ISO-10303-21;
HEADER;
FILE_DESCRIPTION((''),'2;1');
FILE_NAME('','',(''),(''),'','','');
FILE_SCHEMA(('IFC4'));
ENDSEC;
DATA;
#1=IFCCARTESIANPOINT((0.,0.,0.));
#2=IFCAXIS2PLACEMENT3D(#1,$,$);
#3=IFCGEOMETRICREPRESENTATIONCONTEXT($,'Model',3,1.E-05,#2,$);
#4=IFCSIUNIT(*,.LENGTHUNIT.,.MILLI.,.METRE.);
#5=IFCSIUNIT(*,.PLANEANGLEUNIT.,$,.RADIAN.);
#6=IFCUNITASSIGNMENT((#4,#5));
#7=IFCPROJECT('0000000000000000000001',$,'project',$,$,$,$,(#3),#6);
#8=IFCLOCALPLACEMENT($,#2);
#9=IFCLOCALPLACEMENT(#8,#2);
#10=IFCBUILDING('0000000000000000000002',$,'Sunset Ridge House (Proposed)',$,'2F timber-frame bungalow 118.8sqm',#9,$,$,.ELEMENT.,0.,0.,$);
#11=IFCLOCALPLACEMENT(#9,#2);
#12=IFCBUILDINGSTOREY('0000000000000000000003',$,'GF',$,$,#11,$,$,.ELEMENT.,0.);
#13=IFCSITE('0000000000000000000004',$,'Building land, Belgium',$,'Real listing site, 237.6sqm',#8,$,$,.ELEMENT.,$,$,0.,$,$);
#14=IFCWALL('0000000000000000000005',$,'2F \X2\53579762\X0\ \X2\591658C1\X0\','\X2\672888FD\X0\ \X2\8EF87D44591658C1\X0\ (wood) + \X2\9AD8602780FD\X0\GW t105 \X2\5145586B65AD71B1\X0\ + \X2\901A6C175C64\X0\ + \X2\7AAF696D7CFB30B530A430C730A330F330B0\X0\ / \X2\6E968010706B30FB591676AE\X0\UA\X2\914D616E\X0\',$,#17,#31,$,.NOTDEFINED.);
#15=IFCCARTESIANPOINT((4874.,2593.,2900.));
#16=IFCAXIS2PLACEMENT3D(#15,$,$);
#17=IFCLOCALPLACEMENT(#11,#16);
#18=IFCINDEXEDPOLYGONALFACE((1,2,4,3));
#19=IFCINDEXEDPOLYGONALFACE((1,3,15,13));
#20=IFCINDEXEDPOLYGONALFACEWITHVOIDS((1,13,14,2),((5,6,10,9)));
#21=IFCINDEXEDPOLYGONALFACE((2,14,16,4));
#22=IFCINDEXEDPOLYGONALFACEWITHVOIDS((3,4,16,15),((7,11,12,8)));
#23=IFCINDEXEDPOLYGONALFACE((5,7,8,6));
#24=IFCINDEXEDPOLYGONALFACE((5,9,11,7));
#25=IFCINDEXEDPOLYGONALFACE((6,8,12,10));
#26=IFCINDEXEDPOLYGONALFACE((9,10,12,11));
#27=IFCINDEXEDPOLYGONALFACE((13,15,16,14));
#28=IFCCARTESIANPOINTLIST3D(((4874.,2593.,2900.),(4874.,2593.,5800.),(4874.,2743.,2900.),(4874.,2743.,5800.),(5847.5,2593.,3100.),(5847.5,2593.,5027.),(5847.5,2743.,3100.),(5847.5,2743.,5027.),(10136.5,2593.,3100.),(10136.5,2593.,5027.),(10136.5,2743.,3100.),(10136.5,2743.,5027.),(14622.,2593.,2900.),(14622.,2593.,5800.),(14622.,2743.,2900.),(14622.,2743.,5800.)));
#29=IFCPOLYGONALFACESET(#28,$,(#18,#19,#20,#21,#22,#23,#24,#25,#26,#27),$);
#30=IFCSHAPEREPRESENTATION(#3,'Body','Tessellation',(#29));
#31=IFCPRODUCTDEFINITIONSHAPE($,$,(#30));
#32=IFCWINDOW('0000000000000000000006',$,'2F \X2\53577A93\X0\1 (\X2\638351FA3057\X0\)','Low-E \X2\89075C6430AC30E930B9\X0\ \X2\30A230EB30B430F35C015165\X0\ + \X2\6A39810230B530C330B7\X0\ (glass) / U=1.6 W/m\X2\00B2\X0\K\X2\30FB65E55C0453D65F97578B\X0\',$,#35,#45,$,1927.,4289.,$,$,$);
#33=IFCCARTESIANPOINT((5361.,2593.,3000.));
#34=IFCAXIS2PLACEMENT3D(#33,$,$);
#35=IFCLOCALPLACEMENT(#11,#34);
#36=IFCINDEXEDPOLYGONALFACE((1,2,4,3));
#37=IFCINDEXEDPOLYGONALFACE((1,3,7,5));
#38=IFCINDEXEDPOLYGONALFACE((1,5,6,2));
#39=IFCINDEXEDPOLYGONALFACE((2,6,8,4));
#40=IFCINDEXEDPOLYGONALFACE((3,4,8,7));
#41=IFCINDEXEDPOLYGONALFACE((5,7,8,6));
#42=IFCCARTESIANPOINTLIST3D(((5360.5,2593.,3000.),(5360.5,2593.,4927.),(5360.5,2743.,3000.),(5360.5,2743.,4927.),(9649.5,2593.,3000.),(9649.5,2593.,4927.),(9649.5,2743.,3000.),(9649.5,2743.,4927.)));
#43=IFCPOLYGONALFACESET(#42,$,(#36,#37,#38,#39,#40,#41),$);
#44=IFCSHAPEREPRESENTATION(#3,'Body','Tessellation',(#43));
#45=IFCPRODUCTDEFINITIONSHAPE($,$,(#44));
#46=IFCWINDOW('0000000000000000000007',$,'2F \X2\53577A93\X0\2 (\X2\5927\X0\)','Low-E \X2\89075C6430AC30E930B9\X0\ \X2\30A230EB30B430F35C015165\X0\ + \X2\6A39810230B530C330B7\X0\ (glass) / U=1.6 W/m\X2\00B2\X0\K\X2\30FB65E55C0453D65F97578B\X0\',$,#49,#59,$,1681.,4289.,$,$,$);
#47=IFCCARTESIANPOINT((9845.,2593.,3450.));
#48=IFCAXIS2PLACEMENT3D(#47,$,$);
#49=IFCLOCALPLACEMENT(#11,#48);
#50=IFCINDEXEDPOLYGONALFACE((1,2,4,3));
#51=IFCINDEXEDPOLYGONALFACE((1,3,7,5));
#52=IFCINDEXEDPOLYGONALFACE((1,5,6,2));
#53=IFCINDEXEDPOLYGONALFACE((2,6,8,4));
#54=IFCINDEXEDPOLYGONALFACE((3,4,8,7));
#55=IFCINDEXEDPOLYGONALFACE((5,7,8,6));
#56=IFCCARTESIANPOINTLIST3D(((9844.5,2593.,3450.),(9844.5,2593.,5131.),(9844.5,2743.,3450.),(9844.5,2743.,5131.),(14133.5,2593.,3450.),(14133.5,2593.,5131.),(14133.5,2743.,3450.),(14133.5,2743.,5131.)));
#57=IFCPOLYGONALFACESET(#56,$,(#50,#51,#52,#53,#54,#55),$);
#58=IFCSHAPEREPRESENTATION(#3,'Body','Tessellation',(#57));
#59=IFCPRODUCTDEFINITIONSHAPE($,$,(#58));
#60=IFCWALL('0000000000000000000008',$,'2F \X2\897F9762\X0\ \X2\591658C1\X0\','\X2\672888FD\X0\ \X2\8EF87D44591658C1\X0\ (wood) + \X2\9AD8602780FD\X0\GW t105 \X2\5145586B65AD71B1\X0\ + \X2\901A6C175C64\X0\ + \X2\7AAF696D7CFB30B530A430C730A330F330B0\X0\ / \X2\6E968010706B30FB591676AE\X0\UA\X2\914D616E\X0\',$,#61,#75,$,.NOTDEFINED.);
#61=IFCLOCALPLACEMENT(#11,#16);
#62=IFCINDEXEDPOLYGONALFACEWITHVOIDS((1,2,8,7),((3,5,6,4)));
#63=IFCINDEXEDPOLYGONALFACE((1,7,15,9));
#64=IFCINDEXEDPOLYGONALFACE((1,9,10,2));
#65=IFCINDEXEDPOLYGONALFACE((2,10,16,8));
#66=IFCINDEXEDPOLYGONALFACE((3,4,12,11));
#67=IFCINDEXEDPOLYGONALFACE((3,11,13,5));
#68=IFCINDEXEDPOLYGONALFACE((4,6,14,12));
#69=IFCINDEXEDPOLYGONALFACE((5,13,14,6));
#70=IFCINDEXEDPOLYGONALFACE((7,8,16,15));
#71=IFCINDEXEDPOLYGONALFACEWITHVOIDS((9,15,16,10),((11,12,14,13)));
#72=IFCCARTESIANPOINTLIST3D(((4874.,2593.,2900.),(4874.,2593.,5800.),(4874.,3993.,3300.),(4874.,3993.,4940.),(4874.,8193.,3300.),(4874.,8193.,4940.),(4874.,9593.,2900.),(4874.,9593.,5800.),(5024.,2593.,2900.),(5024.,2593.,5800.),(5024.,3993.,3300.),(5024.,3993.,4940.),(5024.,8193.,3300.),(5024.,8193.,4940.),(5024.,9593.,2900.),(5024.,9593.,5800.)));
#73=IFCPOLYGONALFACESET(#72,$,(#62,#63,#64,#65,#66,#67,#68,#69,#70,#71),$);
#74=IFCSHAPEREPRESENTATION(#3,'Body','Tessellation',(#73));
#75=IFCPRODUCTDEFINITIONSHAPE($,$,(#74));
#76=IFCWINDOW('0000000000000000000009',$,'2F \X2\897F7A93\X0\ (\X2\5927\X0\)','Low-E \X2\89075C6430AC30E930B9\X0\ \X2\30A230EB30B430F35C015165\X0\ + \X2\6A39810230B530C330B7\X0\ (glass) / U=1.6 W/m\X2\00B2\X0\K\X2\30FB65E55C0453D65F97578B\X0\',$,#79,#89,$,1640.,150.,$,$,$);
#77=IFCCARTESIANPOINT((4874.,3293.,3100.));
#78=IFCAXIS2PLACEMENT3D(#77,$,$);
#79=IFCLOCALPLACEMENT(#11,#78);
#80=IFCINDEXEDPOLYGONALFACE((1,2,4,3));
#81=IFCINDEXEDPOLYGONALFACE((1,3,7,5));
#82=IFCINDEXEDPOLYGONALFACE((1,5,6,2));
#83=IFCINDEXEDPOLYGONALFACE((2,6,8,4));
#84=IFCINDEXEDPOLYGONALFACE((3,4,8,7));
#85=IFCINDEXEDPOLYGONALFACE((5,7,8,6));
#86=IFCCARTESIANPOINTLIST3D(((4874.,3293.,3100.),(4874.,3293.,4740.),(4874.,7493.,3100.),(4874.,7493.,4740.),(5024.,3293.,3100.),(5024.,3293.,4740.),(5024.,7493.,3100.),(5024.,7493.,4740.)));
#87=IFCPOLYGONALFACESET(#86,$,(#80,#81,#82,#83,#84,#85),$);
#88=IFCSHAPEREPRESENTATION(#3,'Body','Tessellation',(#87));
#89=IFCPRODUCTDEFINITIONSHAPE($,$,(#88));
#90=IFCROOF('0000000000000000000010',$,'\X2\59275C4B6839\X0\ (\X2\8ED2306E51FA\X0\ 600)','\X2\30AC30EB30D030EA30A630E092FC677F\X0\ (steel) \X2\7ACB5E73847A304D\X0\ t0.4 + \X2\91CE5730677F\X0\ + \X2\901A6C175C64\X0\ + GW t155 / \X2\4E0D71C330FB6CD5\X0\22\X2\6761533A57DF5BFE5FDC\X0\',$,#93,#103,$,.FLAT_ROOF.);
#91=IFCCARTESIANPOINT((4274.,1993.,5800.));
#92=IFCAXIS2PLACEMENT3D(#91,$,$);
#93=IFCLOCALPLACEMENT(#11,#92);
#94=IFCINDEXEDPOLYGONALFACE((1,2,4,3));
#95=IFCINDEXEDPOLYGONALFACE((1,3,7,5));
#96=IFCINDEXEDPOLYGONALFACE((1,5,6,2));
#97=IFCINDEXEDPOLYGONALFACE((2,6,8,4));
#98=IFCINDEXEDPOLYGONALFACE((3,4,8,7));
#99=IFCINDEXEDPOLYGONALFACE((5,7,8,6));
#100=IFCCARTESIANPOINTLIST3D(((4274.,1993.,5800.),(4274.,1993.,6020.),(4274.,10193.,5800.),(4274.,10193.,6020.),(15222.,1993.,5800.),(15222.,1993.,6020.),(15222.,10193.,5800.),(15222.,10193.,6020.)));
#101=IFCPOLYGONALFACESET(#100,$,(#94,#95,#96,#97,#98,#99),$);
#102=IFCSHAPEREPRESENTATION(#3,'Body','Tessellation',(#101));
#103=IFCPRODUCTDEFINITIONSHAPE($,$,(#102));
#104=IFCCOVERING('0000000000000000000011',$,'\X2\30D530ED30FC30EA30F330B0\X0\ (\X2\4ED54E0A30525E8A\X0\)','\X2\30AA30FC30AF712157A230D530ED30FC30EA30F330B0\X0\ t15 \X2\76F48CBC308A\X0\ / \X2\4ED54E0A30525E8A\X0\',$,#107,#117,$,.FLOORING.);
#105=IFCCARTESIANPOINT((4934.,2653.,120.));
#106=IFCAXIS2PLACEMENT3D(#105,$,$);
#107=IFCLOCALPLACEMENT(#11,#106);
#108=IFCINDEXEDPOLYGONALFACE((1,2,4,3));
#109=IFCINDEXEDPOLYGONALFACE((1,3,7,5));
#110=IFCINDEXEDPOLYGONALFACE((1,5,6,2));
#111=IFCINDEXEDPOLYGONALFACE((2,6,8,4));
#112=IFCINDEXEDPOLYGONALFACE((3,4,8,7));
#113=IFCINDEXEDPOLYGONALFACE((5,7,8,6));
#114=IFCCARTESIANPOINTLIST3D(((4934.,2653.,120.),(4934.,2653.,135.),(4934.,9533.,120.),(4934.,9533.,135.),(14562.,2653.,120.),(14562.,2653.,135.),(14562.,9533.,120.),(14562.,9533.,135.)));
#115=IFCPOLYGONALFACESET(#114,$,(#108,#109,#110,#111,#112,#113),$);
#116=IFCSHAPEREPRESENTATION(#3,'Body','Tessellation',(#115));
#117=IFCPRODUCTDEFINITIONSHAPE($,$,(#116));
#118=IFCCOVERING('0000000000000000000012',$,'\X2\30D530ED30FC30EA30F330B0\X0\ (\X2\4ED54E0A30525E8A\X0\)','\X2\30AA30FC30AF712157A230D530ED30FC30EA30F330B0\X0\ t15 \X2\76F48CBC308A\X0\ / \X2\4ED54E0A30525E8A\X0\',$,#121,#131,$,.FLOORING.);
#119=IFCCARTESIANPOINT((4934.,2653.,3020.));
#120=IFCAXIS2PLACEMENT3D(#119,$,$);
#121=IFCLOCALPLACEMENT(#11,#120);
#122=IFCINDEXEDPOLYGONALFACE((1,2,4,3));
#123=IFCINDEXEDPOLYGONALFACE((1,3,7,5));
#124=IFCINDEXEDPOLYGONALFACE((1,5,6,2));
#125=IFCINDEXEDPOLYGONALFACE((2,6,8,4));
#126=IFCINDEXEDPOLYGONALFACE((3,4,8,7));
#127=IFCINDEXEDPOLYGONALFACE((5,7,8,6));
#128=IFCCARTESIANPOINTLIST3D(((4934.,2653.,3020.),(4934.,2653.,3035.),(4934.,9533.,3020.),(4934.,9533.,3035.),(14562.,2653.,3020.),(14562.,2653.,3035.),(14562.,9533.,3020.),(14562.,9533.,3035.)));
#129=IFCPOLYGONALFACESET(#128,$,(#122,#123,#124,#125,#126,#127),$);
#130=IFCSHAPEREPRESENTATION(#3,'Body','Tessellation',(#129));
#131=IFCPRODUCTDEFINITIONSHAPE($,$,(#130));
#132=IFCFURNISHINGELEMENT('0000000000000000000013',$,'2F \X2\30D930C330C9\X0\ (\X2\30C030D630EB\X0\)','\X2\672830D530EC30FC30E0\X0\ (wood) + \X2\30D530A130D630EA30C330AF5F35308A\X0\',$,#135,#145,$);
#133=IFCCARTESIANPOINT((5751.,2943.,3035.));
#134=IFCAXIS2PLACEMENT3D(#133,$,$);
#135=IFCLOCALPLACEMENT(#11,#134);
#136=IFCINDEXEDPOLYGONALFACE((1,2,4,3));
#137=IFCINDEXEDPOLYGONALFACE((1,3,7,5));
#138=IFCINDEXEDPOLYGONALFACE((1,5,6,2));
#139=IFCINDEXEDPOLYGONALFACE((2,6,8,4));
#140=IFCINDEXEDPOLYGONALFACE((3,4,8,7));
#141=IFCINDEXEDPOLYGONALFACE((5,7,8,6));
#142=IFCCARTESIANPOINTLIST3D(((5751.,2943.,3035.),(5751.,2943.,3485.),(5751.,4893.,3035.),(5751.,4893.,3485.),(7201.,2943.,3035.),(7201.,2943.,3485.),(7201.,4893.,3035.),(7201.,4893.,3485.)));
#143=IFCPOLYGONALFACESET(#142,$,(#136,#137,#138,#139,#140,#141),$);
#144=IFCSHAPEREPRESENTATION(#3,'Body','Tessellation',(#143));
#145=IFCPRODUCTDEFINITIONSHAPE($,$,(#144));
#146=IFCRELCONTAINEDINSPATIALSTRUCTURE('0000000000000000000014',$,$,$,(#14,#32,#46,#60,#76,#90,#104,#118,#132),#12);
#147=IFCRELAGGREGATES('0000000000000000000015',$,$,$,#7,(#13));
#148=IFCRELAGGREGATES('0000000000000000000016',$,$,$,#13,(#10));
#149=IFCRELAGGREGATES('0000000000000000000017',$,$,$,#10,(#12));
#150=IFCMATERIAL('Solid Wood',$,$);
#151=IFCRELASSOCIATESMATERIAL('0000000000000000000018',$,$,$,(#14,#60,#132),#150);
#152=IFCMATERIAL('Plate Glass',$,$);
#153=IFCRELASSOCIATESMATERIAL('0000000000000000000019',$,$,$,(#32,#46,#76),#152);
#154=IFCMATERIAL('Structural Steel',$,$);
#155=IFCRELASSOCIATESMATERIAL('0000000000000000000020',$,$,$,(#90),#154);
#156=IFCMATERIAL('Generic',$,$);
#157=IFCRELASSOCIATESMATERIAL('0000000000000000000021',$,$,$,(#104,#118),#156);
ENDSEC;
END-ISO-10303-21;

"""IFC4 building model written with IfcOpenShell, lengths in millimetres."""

from ifc_helpers import new_model, si_unit, frame, frame_2d, origin, place, context, project, spatial, rectangle, extrude, material, element, fill, save


model = new_model("IFC4")

# Units and contexts
model_context = context("Model", 3, precision=1e-05, world=origin())
ifc_project = project(units=[si_unit("LENGTHUNIT", "METRE", prefix="MILLI"), si_unit("PLANEANGLEUNIT", "RADIAN")], contexts=[model_context])

# Site, building, storey
site_placement = place(None, origin())
site = spatial("IfcSite", under=ifc_project, at=site_placement, Name="Building land, Belgium", ObjectType="Real listing site, 237.6sqm", CompositionType="ELEMENT", RefElevation=0.0)
building_placement = place(site_placement, origin())
building = spatial("IfcBuilding", under=site, at=building_placement, Name="Sunset Ridge House (Proposed)", ObjectType="2F timber-frame bungalow 118.8sqm", CompositionType="ELEMENT", ElevationOfRefHeight=0.0, ElevationOfTerrain=0.0)
storey_placement = place(building_placement, origin())
storey = spatial("IfcBuildingStorey", under=building, at=storey_placement, Name="GF", CompositionType="ELEMENT", Elevation=0.0)

# Shared definitions
ifc_material_1 = material(Name="Solid Wood")

# Shared definitions
ifc_material_2 = material(Name="Plate Glass")

# Wall, openings, windows
wall_1_placement = place(storey_placement, frame((4874.0, 2593.0, 2900.0)))
wall_1 = element("IfcWall", 1, at=wall_1_placement, inside=storey, material=ifc_material_1, Name="2F 南面 外壁", Description="木製 軸組外壁 (wood) + 高性能GW t105 充填断熱 + 通気層 + 窯業系サイディング / 準耐火・外皮UA配慮", PredefinedType="NOTDEFINED", context=model_context, shape_type="SweptSolid", body=[
    extrude(rectangle(XDim=9748.0, YDim=150.0, at=frame_2d((4874.0, 75.0))), frame((4874.0, 2593.0, 2900.0)), (0.0, 0.0, 1.0), 2900.0),
])
opening_1_placement = place(storey_placement, frame((5361.0, 2593.0, 3000.0)))
opening_1 = element("IfcOpeningElement", 2, at=opening_1_placement, cuts=wall_1, PredefinedType="NOTDEFINED", context=model_context, shape_type="SweptSolid", body=[
    extrude(rectangle(XDim=4289.0, YDim=150.0, at=frame_2d((2144.0, 75.0))), frame((5361.0, 2593.0, 3000.0)), (0.0, 0.0, 1.0), 1927.0),
])
opening_2_placement = place(storey_placement, frame((9845.0, 2593.0, 3450.0)))
opening_2 = element("IfcOpeningElement", 3, at=opening_2_placement, cuts=wall_1, PredefinedType="NOTDEFINED", context=model_context, shape_type="SweptSolid", body=[
    extrude(rectangle(XDim=4289.0, YDim=150.0, at=frame_2d((2144.0, 75.0))), frame((9845.0, 2593.0, 3450.0)), (0.0, 0.0, 1.0), 1681.0),
])
window_1_placement = place(storey_placement, frame((5361.0, 2593.0, 3000.0)))
window_1 = element("IfcWindow", 4, at=window_1_placement, inside=storey, material=ifc_material_2, Name="2F 南窓1 (掃出し)", Description="Low-E 複層ガラス アルゴン封入 + 樹脂サッシ (glass) / U=1.6 W/m²K・日射取得型", OverallHeight=1927.0, OverallWidth=4289.0, context=model_context, shape_type="SweptSolid", body=[
    extrude(rectangle(XDim=4289.0, YDim=150.0, at=frame_2d((2144.0, 75.0))), frame((5361.0, 2593.0, 3000.0)), (0.0, 0.0, 1.0), 1927.0),
])
fill(opening_1, window_1)
window_2_placement = place(storey_placement, frame((9845.0, 2593.0, 3450.0)))
window_2 = element("IfcWindow", 5, at=window_2_placement, inside=storey, material=ifc_material_2, Name="2F 南窓2 (大)", Description="Low-E 複層ガラス アルゴン封入 + 樹脂サッシ (glass) / U=1.6 W/m²K・日射取得型", OverallHeight=1681.0, OverallWidth=4289.0, context=model_context, shape_type="SweptSolid", body=[
    extrude(rectangle(XDim=4289.0, YDim=150.0, at=frame_2d((2144.0, 75.0))), frame((9845.0, 2593.0, 3450.0)), (0.0, 0.0, 1.0), 1681.0),
])
fill(opening_2, window_2)

# Wall, opening, window
wall_2_placement = place(storey_placement, frame((4874.0, 2593.0, 2900.0)))
wall_2 = element("IfcWall", 6, at=wall_2_placement, inside=storey, material=ifc_material_1, Name="2F 西面 外壁", Description="木製 軸組外壁 (wood) + 高性能GW t105 充填断熱 + 通気層 + 窯業系サイディング / 準耐火・外皮UA配慮", PredefinedType="NOTDEFINED", context=model_context, shape_type="SweptSolid", body=[
    extrude(rectangle(XDim=150.0, YDim=7000.0, at=frame_2d((75.0, 3500.0))), frame((4874.0, 2593.0, 2900.0)), (0.0, 0.0, 1.0), 2900.0),
])
opening_3_placement = place(storey_placement, frame((4874.0, 3293.0, 3100.0)))
opening_3 = element("IfcOpeningElement", 7, at=opening_3_placement, cuts=wall_2, PredefinedType="NOTDEFINED", context=model_context, shape_type="SweptSolid", body=[
    extrude(rectangle(XDim=150.0, YDim=4200.0, at=frame_2d((75.0, 2100.0))), frame((4874.0, 3293.0, 3100.0)), (0.0, 0.0, 1.0), 1640.0),
])
window_3_placement = place(storey_placement, frame((4874.0, 3293.0, 3100.0)))
window_3 = element("IfcWindow", 8, at=window_3_placement, inside=storey, material=ifc_material_2, Name="2F 西窓 (大)", Description="Low-E 複層ガラス アルゴン封入 + 樹脂サッシ (glass) / U=1.6 W/m²K・日射取得型", OverallHeight=1640.0, OverallWidth=150.0, context=model_context, shape_type="SweptSolid", body=[
    extrude(rectangle(XDim=150.0, YDim=4200.0, at=frame_2d((75.0, 2100.0))), frame((4874.0, 3293.0, 3100.0)), (0.0, 0.0, 1.0), 1640.0),
])
fill(opening_3, window_3)

# Roof
ifc_material_3 = material(Name="Structural Steel")
roof_placement = place(storey_placement, frame((4274.0, 1993.0, 5800.0)))
element("IfcRoof", 9, at=roof_placement, inside=storey, material=ifc_material_3, Name="大屋根 (軒の出 600)", Description="ガルバリウム鋼板 (steel) 立平葺き t0.4 + 野地板 + 通気層 + GW t155 / 不燃・法22条区域対応", PredefinedType="FLAT_ROOF", context=model_context, shape_type="SweptSolid", body=[
    extrude(rectangle(XDim=10948.0, YDim=8200.0, at=frame_2d((5474.0, 4100.0))), frame((4274.0, 1993.0, 5800.0)), (0.0, 0.0, 1.0), 220.0),
])

# Coverings
ifc_material_4 = material(Name="Generic")
covering_1_placement = place(storey_placement, frame((4934.0, 2653.0, 120.0)))
element("IfcCovering", 10, at=covering_1_placement, inside=storey, material=ifc_material_4, Name="フローリング (仕上げ床)", Description="オーク無垢フローリング t15 直貼り / 仕上げ床", PredefinedType="FLOORING", context=model_context, shape_type="SweptSolid", body=[
    extrude(rectangle(XDim=9628.0, YDim=6880.0, at=frame_2d((4814.0, 3440.0))), frame((4934.0, 2653.0, 120.0)), (0.0, 0.0, 1.0), 15.0),
])
covering_2_placement = place(storey_placement, frame((4934.0, 2653.0, 3020.0)))
element("IfcCovering", 11, at=covering_2_placement, inside=storey, material=ifc_material_4, Name="フローリング (仕上げ床)", Description="オーク無垢フローリング t15 直貼り / 仕上げ床", PredefinedType="FLOORING", context=model_context, shape_type="SweptSolid", body=[
    extrude(rectangle(XDim=9628.0, YDim=6880.0, at=frame_2d((4814.0, 3440.0))), frame((4934.0, 2653.0, 3020.0)), (0.0, 0.0, 1.0), 15.0),
])

# Furnishing element
furnishing_placement = place(storey_placement, frame((5751.0, 2943.0, 3035.0)))
element("IfcFurnishingElement", 12, at=furnishing_placement, inside=storey, material=ifc_material_1, Name="2F ベッド (ダブル)", Description="木フレーム (wood) + ファブリック張り", context=model_context, shape_type="SweptSolid", body=[
    extrude(rectangle(XDim=1450.0, YDim=1950.0, at=frame_2d((725.0, 975.0))), frame((5751.0, 2943.0, 3035.0)), (0.0, 0.0, 1.0), 450.0),
])

save(model, "model.ifc")
